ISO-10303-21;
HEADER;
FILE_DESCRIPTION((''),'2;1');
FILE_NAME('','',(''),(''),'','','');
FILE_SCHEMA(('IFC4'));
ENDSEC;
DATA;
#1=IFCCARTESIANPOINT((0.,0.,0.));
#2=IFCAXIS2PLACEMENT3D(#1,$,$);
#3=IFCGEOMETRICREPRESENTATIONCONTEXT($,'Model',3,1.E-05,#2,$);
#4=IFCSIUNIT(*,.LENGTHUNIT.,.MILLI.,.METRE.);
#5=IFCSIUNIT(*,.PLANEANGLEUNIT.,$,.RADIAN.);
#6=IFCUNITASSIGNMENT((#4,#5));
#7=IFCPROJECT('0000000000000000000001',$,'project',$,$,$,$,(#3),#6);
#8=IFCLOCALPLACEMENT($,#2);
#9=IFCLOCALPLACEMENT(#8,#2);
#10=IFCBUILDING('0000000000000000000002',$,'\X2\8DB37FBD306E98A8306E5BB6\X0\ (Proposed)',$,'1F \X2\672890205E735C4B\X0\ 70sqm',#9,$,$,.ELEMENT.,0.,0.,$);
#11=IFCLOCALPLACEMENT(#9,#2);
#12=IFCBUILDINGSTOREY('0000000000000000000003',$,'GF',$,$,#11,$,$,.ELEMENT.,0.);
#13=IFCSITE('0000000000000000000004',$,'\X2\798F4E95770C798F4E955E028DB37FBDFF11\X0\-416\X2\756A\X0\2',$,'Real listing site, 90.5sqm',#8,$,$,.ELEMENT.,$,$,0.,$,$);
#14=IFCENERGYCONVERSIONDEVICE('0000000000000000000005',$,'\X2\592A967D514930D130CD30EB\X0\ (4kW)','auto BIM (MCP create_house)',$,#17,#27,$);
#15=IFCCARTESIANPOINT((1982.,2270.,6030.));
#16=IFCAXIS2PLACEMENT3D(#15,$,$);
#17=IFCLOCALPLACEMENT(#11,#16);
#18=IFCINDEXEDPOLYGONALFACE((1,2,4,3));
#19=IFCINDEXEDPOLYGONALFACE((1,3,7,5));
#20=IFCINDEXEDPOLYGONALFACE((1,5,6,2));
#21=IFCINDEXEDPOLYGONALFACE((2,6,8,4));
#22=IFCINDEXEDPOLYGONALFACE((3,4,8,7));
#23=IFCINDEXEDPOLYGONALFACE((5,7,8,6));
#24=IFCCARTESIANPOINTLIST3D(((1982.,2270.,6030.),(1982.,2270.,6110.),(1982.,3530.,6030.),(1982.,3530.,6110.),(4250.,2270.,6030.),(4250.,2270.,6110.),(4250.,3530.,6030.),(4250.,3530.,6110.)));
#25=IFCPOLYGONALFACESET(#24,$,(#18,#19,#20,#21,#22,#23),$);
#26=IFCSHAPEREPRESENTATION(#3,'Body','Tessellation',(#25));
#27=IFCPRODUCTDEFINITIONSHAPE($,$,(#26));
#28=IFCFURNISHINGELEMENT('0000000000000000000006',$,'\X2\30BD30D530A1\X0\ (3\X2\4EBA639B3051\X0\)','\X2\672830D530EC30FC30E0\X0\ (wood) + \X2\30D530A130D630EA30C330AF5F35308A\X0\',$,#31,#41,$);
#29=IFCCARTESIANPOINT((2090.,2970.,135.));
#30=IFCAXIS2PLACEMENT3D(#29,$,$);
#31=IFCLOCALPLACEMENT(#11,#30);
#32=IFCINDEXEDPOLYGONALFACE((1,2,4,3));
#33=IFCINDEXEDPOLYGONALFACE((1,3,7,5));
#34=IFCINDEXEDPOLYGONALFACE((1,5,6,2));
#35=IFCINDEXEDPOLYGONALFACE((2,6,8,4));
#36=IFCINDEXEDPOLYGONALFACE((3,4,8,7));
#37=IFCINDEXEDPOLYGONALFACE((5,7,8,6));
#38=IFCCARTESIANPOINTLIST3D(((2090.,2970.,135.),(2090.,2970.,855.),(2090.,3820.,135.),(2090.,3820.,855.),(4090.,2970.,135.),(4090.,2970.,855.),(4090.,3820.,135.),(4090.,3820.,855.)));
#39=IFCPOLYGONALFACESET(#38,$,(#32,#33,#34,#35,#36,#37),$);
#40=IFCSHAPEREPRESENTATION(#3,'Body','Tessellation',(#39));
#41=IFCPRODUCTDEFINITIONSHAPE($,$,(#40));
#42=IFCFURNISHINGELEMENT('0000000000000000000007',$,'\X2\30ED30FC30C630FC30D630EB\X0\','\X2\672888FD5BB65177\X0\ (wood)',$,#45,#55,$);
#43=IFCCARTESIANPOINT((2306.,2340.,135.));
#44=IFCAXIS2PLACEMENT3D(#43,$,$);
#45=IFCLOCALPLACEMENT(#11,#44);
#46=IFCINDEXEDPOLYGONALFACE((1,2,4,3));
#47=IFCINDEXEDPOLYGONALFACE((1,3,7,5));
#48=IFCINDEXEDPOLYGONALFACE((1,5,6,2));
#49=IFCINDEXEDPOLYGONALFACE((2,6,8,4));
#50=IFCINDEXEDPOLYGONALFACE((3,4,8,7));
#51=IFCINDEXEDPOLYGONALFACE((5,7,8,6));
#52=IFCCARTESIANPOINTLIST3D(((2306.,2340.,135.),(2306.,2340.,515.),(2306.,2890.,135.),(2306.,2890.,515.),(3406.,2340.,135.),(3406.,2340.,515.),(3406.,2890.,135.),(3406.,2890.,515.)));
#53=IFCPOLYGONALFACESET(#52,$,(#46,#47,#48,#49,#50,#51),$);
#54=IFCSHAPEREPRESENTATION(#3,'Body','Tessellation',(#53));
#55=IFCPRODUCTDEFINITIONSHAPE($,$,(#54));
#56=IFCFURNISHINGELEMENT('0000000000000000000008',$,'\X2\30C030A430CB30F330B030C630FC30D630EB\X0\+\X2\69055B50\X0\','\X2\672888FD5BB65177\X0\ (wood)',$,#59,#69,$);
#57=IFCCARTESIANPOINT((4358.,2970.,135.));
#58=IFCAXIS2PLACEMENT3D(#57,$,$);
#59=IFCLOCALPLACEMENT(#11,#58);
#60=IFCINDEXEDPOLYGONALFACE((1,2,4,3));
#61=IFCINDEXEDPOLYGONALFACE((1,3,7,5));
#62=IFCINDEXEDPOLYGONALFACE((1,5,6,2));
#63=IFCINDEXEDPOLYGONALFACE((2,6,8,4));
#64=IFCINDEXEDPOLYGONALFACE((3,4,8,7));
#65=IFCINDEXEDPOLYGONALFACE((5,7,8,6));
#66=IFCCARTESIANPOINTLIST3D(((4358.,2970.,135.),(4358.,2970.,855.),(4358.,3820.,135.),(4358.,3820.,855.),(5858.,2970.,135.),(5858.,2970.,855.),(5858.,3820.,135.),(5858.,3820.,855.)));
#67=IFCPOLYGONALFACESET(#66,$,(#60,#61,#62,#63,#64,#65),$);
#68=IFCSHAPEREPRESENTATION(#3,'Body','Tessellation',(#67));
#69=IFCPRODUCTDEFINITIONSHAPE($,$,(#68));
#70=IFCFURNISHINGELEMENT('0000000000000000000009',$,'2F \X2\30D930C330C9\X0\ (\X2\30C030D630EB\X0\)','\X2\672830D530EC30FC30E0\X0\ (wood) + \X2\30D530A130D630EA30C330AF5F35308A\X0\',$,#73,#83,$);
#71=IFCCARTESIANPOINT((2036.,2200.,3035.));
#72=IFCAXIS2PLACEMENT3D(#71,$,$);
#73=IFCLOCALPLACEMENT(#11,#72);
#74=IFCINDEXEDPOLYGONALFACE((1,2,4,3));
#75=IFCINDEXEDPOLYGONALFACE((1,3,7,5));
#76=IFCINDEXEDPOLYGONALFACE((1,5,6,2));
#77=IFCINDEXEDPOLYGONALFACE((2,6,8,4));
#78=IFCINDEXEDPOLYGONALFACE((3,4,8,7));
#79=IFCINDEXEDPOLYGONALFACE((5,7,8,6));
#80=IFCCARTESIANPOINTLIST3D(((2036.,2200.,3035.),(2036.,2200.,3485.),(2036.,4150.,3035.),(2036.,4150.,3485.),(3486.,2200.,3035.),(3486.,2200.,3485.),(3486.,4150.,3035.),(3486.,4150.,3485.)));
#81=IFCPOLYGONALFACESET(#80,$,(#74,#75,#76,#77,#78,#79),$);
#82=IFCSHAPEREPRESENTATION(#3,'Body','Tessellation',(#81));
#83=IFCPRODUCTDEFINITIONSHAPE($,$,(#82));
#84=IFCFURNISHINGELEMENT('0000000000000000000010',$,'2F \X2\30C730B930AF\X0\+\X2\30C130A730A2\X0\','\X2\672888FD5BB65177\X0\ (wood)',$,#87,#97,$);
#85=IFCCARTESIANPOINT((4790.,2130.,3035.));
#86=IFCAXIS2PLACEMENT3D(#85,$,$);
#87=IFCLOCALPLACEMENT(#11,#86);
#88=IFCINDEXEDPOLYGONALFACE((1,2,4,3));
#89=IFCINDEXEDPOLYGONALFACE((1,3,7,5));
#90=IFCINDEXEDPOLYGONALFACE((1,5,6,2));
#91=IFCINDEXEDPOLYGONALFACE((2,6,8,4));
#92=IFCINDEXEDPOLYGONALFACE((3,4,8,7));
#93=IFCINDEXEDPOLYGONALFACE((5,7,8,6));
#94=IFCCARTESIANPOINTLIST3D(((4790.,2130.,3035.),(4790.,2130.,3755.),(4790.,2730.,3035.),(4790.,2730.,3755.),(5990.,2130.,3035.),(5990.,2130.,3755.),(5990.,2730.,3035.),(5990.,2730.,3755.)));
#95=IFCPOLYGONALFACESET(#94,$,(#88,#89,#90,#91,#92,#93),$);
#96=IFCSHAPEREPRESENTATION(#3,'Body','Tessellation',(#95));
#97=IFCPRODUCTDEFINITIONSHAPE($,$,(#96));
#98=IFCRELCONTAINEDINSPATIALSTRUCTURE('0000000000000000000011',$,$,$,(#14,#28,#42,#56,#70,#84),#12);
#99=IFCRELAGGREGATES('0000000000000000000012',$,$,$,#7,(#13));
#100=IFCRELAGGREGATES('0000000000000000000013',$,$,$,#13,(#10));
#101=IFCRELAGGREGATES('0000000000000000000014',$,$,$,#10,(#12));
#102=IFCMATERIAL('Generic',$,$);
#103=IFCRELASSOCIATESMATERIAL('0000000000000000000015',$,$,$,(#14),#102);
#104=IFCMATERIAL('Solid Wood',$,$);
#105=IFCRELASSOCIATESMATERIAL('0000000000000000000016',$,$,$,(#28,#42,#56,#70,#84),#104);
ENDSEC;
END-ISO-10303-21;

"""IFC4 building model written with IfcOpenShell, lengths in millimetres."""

from ifc_helpers import new_model, si_unit, frame, frame_2d, origin, place, context, project, spatial, rectangle, extrude, material, element, save


model = new_model("IFC4")

# Units and contexts
model_context = context("Model", 3, precision=1e-05, world=origin())
ifc_project = project(units=[si_unit("LENGTHUNIT", "METRE", prefix="MILLI"), si_unit("PLANEANGLEUNIT", "RADIAN")], contexts=[model_context])

# Site, building, storey
site_placement = place(None, origin())
site = spatial("IfcSite", under=ifc_project, at=site_placement, Name="福井県福井市足羽１-416番2", ObjectType="Real listing site, 90.5sqm", CompositionType="ELEMENT", RefElevation=0.0)
building_placement = place(site_placement, origin())
building = spatial("IfcBuilding", under=site, at=building_placement, Name="足羽の風の家 (Proposed)", ObjectType="1F 木造平屋 70sqm", CompositionType="ELEMENT", ElevationOfRefHeight=0.0, ElevationOfTerrain=0.0)
storey_placement = place(building_placement, origin())
storey = spatial("IfcBuildingStorey", under=building, at=storey_placement, Name="GF", CompositionType="ELEMENT", Elevation=0.0)

# Shared definitions
ifc_material_1 = material(Name="Solid Wood")

# Shared definitions
ifc_material_2 = material(Name="Generic")

# Energy conversion device
energy_conversion_device_placement = place(storey_placement, frame((1982.0, 2270.0, 6030.0)))
element("IfcEnergyConversionDevice", 1, at=energy_conversion_device_placement, inside=storey, material=ifc_material_2, Name="太陽光パネル (4kW)", Description="auto BIM (MCP create_house)", context=model_context, shape_type="SweptSolid", body=[
    extrude(rectangle(XDim=2268.0, YDim=1260.0, at=frame_2d((1134.0, 630.0))), frame((1982.0, 2270.0, 6030.0)), (0.0, 0.0, 1.0), 80.0),
])

# Furnishing elements
furnishing_1_placement = place(storey_placement, frame((2090.0, 2970.0, 135.0)))
element("IfcFurnishingElement", 2, at=furnishing_1_placement, inside=storey, material=ifc_material_1, Name="ソファ (3人掛け)", Description="木フレーム (wood) + ファブリック張り", context=model_context, shape_type="SweptSolid", body=[
    extrude(rectangle(XDim=2000.0, YDim=850.0, at=frame_2d((1000.0, 425.0))), frame((2090.0, 2970.0, 135.0)), (0.0, 0.0, 1.0), 720.0),
])
furnishing_2_placement = place(storey_placement, frame((2306.0, 2340.0, 135.0)))
element("IfcFurnishingElement", 3, at=furnishing_2_placement, inside=storey, material=ifc_material_1, Name="ローテーブル", Description="木製家具 (wood)", context=model_context, shape_type="SweptSolid", body=[
    extrude(rectangle(XDim=1100.0, YDim=550.0, at=frame_2d((550.0, 275.0))), frame((2306.0, 2340.0, 135.0)), (0.0, 0.0, 1.0), 380.0),
])
furnishing_3_placement = place(storey_placement, frame((4358.0, 2970.0, 135.0)))
element("IfcFurnishingElement", 4, at=furnishing_3_placement, inside=storey, material=ifc_material_1, Name="ダイニングテーブル+椅子", Description="木製家具 (wood)", context=model_context, shape_type="SweptSolid", body=[
    extrude(rectangle(XDim=1500.0, YDim=850.0, at=frame_2d((750.0, 425.0))), frame((4358.0, 2970.0, 135.0)), (0.0, 0.0, 1.0), 720.0),
])
furnishing_4_placement = place(storey_placement, frame((2036.0, 2200.0, 3035.0)))
element("IfcFurnishingElement", 5, at=furnishing_4_placement, inside=storey, material=ifc_material_1, Name="2F ベッド (ダブル)", Description="木フレーム (wood) + ファブリック張り", context=model_context, shape_type="SweptSolid", body=[
    extrude(rectangle(XDim=1450.0, YDim=1950.0, at=frame_2d((725.0, 975.0))), frame((2036.0, 2200.0, 3035.0)), (0.0, 0.0, 1.0), 450.0),
])
furnishing_5_placement = place(storey_placement, frame((4790.0, 2130.0, 3035.0)))
element("IfcFurnishingElement", 6, at=furnishing_5_placement, inside=storey, material=ifc_material_1, Name="2F デスク+チェア", Description="木製家具 (wood)", context=model_context, shape_type="SweptSolid", body=[
    extrude(rectangle(XDim=1200.0, YDim=600.0, at=frame_2d((600.0, 300.0))), frame((4790.0, 2130.0, 3035.0)), (0.0, 0.0, 1.0), 720.0),
])

save(model, "model.ifc")
